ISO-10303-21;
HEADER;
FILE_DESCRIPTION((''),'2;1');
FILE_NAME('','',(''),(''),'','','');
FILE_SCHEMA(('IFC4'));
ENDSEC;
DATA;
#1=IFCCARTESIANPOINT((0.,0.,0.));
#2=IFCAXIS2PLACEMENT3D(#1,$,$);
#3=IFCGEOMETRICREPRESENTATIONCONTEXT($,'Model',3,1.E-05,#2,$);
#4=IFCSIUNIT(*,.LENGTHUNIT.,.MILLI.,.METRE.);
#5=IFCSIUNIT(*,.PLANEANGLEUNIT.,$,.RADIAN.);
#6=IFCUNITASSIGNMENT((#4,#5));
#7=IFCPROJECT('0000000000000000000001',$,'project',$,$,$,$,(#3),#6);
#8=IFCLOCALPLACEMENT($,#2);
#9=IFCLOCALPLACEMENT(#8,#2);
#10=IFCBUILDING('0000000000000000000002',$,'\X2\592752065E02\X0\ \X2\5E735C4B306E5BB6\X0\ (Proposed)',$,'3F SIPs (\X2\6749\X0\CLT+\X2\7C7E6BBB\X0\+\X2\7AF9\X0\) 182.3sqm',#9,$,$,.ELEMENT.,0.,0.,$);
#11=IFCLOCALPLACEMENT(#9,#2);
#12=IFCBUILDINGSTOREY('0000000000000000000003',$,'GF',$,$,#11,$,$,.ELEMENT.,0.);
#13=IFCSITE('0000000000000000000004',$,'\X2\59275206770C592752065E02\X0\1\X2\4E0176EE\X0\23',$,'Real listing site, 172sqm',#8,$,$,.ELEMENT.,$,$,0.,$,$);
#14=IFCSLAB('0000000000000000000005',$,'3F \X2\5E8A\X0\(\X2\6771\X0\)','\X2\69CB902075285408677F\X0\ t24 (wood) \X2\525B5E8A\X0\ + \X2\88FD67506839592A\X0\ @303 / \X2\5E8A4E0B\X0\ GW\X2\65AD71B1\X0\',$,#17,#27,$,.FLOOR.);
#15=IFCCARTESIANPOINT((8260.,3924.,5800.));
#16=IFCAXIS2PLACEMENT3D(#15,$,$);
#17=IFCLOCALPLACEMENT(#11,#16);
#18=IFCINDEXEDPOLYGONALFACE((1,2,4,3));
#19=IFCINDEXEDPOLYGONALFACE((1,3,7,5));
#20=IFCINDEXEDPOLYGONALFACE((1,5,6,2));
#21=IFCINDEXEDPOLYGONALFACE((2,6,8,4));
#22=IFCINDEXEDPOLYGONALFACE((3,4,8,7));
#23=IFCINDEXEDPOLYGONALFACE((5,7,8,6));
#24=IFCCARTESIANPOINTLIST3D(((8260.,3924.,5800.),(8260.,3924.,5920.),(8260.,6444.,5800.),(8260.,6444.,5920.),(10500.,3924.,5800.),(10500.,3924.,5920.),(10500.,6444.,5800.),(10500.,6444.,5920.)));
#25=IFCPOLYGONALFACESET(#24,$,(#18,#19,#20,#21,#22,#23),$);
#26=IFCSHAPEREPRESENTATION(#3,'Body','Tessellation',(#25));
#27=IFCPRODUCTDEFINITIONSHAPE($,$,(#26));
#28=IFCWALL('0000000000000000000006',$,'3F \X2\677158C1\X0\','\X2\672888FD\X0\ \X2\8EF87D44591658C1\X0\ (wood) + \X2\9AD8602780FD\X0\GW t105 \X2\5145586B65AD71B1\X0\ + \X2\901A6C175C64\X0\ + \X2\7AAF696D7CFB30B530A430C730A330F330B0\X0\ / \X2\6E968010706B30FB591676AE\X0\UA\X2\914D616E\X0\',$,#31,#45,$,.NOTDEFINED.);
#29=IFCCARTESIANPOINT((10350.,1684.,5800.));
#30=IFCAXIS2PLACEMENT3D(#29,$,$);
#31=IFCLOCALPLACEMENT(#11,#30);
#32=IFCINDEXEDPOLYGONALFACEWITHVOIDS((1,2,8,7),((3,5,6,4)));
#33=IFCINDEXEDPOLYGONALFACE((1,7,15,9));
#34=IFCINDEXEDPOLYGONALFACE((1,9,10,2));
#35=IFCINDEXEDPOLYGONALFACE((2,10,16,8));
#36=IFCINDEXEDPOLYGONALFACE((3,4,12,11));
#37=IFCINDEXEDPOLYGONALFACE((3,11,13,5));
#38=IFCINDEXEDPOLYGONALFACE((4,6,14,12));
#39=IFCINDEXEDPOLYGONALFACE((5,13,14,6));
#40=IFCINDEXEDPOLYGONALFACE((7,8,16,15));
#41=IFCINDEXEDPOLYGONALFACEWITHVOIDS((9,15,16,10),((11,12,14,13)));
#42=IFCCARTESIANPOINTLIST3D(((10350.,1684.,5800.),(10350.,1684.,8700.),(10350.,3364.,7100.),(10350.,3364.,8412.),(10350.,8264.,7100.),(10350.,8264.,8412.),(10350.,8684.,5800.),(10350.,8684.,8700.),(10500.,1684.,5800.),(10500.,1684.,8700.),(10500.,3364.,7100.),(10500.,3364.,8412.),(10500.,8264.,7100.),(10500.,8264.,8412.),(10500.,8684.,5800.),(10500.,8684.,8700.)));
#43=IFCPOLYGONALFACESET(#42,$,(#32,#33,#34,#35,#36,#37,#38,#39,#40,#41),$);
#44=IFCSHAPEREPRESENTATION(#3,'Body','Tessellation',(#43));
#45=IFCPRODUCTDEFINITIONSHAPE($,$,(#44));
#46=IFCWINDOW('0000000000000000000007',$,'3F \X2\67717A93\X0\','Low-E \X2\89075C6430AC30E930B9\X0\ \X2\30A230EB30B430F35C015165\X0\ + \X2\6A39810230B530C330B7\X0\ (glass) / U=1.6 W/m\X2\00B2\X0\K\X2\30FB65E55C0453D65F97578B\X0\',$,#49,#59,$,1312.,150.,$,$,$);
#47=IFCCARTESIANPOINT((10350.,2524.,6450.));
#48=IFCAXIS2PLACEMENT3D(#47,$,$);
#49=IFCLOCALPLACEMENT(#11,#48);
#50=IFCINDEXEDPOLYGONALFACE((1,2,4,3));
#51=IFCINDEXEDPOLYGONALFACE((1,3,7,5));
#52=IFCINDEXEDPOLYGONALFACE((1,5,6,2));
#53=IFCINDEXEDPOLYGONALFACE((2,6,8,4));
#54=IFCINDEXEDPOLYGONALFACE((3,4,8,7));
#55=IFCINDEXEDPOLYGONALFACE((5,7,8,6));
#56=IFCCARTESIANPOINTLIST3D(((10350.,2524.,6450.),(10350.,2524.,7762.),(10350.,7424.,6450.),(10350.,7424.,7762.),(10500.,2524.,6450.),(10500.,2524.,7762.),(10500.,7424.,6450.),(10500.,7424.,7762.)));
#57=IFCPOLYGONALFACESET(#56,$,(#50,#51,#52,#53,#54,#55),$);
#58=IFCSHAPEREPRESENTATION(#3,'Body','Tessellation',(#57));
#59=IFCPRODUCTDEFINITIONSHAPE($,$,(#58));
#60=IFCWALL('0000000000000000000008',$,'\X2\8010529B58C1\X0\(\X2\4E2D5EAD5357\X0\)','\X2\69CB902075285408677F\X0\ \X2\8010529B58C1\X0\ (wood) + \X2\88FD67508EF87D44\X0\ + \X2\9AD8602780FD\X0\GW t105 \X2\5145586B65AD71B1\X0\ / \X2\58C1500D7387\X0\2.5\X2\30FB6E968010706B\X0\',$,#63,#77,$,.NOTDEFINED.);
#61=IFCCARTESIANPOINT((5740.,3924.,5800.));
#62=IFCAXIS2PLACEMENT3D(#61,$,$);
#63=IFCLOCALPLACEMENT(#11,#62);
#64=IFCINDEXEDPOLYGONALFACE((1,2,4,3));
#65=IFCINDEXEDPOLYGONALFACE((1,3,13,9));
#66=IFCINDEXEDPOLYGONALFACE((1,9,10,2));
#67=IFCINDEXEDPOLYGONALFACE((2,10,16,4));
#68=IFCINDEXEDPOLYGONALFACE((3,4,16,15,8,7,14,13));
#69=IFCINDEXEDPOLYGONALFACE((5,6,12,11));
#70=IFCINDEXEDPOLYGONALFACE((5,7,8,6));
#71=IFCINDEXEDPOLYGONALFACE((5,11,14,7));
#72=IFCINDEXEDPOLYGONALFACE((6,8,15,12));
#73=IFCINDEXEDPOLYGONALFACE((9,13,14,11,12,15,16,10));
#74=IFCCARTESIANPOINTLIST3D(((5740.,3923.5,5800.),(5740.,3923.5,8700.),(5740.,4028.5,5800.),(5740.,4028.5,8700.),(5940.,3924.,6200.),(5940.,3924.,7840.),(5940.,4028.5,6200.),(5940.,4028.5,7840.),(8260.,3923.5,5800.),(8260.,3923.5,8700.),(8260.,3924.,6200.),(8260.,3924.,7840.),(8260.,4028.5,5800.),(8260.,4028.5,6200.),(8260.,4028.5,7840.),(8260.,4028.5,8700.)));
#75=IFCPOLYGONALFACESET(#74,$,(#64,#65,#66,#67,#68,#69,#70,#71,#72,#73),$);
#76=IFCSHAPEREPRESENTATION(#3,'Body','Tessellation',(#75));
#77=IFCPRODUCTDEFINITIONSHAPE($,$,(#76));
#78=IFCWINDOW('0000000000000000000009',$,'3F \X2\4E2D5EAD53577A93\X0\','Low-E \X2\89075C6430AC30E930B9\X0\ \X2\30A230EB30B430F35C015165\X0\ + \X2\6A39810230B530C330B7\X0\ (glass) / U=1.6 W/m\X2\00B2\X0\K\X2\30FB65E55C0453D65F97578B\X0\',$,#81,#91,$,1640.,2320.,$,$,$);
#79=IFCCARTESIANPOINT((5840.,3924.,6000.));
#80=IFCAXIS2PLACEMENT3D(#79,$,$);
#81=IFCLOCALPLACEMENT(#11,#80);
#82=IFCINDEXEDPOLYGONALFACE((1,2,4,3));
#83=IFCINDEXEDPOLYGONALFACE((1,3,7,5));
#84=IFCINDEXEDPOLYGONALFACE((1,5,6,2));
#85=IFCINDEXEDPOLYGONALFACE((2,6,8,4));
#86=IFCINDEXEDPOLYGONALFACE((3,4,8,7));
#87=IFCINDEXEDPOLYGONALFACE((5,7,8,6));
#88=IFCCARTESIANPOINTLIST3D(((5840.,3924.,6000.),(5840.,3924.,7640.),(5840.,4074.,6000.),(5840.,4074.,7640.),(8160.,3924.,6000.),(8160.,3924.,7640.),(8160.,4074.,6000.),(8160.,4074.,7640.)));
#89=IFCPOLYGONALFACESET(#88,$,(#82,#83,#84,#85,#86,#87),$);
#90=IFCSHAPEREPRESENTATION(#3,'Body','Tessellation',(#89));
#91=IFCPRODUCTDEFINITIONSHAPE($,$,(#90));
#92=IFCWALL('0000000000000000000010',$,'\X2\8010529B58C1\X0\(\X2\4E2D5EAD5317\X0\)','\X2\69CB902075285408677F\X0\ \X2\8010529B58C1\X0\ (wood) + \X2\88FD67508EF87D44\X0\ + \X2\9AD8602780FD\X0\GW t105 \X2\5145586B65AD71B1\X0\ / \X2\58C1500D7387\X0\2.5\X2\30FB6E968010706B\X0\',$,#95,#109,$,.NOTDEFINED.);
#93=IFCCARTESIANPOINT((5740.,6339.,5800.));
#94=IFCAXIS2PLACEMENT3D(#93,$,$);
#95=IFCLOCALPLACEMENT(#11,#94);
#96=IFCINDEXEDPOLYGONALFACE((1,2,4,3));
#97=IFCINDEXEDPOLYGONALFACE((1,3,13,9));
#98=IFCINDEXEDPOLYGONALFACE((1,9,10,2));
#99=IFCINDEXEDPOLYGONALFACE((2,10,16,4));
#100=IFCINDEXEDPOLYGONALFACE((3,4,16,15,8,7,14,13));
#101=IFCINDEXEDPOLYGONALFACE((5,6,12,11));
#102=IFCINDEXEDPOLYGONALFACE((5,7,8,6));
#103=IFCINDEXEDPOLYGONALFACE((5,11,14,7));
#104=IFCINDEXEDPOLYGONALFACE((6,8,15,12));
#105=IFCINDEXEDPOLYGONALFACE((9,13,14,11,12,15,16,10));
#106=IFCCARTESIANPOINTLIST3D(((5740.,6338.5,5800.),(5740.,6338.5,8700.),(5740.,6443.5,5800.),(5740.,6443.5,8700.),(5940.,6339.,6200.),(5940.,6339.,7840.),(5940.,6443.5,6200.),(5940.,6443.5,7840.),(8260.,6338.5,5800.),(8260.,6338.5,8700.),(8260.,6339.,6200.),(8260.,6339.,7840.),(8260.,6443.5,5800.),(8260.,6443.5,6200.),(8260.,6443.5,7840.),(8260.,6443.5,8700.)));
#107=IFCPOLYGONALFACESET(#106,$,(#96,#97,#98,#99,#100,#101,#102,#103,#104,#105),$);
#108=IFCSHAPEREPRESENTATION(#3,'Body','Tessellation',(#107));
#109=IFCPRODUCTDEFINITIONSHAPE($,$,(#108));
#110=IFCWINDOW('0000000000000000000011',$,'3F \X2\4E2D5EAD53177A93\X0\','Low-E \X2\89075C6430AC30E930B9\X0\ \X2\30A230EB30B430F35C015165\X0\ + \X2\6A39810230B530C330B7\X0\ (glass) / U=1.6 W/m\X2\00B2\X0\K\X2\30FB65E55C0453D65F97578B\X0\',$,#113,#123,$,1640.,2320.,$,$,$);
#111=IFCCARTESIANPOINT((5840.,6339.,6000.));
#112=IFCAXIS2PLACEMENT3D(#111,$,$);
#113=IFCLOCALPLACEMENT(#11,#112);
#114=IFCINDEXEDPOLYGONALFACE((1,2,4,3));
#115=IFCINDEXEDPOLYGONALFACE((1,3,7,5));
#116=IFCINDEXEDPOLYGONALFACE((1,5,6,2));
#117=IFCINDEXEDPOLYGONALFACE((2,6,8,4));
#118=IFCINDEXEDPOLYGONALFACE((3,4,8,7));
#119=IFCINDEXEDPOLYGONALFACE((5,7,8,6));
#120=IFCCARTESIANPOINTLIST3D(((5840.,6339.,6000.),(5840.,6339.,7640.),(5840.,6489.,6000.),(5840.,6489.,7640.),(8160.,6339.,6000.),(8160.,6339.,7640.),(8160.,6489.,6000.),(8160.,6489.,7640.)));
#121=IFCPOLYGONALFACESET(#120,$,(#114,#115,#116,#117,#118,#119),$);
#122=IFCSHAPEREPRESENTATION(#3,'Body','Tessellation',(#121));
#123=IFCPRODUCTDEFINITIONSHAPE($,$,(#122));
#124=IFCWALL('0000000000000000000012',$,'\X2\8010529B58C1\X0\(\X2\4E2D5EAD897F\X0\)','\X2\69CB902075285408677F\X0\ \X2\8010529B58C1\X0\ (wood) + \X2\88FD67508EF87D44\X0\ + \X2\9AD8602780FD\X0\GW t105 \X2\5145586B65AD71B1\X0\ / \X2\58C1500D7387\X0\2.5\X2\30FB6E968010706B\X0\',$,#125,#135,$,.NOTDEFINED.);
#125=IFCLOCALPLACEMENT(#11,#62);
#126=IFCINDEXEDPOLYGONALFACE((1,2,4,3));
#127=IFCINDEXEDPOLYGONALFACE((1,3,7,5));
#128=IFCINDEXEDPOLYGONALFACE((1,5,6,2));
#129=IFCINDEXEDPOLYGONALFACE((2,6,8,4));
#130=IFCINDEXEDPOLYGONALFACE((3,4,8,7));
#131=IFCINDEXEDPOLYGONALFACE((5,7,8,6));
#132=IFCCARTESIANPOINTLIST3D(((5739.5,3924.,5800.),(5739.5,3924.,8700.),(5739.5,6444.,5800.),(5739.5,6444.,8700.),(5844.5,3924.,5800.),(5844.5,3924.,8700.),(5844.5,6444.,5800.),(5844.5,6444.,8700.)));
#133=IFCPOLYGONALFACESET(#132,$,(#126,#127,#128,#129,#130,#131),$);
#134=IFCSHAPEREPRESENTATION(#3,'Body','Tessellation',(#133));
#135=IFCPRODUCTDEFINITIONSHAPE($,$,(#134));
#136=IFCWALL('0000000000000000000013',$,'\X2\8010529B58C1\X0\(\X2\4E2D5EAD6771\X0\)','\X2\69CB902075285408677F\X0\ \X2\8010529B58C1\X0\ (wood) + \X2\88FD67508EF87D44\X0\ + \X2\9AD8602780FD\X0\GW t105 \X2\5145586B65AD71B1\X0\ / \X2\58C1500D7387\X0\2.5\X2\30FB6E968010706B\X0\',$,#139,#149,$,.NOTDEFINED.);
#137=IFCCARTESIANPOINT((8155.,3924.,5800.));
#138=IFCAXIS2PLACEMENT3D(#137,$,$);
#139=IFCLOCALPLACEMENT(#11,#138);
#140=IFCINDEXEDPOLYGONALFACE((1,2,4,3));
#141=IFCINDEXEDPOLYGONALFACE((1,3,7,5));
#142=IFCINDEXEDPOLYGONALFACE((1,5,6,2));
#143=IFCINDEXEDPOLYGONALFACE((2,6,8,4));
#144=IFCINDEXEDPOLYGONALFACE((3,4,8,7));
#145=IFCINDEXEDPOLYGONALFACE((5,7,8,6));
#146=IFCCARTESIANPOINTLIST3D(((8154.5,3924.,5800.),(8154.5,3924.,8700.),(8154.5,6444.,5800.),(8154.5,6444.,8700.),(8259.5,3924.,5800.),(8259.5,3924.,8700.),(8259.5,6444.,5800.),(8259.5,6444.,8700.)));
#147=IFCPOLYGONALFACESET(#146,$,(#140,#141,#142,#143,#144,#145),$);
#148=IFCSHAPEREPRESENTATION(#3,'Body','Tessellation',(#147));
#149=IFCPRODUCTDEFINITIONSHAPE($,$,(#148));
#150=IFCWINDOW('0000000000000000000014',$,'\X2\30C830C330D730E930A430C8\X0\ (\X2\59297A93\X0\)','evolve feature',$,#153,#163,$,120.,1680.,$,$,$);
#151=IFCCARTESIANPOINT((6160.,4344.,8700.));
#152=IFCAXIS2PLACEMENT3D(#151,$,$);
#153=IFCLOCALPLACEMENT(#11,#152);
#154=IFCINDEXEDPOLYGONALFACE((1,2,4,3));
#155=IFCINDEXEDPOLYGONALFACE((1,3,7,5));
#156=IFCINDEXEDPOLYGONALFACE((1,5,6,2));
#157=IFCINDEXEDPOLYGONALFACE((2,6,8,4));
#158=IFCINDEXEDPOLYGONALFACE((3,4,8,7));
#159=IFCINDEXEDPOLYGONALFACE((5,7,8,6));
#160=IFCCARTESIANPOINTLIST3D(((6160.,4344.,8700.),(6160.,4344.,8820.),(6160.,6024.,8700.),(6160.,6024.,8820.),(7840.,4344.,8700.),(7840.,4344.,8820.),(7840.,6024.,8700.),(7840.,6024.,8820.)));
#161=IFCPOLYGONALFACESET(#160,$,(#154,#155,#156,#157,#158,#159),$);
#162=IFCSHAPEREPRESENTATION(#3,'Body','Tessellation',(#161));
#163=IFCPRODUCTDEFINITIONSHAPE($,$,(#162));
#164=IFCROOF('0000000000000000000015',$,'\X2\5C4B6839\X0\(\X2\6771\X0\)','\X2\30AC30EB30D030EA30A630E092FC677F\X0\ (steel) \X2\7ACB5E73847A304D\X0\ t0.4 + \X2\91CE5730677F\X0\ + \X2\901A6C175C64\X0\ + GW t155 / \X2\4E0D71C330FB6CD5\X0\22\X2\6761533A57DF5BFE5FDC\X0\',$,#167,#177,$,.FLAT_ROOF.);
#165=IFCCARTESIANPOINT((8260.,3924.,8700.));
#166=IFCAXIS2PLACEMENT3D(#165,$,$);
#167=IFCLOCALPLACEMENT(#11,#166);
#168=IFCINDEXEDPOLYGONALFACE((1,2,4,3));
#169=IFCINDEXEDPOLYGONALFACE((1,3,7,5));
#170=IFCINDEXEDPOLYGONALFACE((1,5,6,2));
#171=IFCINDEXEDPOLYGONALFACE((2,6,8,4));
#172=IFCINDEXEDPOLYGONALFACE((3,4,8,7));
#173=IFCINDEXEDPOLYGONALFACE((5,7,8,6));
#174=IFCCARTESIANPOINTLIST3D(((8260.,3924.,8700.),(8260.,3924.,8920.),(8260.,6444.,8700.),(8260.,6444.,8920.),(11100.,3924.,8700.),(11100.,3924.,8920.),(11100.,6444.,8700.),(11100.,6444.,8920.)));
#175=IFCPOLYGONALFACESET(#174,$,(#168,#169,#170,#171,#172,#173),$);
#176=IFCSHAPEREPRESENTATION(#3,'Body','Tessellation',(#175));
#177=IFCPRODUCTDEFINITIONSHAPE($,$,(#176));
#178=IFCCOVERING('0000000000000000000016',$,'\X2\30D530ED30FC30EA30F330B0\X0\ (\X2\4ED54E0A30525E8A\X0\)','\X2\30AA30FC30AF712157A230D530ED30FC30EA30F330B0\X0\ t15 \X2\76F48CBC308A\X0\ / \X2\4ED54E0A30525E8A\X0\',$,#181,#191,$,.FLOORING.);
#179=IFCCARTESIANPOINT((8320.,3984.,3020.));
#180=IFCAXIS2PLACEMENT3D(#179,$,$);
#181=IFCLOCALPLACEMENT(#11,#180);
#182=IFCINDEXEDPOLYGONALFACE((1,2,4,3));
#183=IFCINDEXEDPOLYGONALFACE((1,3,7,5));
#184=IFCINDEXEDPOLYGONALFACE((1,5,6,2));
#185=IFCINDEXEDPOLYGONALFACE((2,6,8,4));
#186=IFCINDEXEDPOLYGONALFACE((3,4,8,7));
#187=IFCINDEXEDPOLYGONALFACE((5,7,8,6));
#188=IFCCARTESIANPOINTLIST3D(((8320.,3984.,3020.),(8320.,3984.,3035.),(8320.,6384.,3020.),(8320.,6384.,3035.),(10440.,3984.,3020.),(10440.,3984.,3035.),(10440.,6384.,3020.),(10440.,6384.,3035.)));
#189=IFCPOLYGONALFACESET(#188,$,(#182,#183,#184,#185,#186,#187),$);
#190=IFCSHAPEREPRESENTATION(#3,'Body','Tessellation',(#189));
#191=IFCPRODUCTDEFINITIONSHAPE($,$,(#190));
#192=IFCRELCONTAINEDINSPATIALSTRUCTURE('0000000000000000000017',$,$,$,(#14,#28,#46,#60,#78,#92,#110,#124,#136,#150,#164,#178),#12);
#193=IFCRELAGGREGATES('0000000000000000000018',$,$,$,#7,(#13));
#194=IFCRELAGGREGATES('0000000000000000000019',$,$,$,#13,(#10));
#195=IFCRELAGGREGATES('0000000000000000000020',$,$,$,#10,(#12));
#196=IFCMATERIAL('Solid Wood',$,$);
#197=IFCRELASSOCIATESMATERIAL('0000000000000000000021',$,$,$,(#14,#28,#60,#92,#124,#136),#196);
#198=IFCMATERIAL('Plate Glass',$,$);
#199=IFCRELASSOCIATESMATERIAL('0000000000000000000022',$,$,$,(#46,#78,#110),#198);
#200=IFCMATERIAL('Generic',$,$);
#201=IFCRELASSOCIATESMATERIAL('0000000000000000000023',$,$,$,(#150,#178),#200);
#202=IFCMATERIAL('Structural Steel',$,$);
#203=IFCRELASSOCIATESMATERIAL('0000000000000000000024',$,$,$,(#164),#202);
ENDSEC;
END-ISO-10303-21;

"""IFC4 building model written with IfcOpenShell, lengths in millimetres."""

from ifc_helpers import new_model, si_unit, frame, frame_2d, origin, place, context, project, spatial, rectangle, extrude, material, element, fill, save


model = new_model("IFC4")

# Units and contexts
model_context = context("Model", 3, precision=1e-05, world=origin())
ifc_project = project(units=[si_unit("LENGTHUNIT", "METRE", prefix="MILLI"), si_unit("PLANEANGLEUNIT", "RADIAN")], contexts=[model_context])

# Site, building, storey
site_placement = place(None, origin())
site = spatial("IfcSite", under=ifc_project, at=site_placement, Name="大分県大分市1丁目23", ObjectType="Real listing site, 172sqm", CompositionType="ELEMENT", RefElevation=0.0)
building_placement = place(site_placement, origin())
building = spatial("IfcBuilding", under=site, at=building_placement, Name="大分市 平屋の家 (Proposed)", ObjectType="3F SIPs (杉CLT+籾殻+竹) 182.3sqm", CompositionType="ELEMENT", ElevationOfRefHeight=0.0, ElevationOfTerrain=0.0)
storey_placement = place(building_placement, origin())
storey = spatial("IfcBuildingStorey", under=building, at=storey_placement, Name="GF", CompositionType="ELEMENT", Elevation=0.0)

# Slab
ifc_material_1 = material(Name="Solid Wood")
slab_placement = place(storey_placement, frame((8260.0, 3924.0, 5800.0)))
element("IfcSlab", 1, at=slab_placement, inside=storey, material=ifc_material_1, Name="3F 床(東)", Description="構造用合板 t24 (wood) 剛床 + 製材根太 @303 / 床下 GW断熱", PredefinedType="FLOOR", context=model_context, shape_type="SweptSolid", body=[
    extrude(rectangle(XDim=2240.0, YDim=2520.0, at=frame_2d((1120.0, 1260.0))), frame((8260.0, 3924.0, 5800.0)), (0.0, 0.0, 1.0), 120.0),
])

# Walls, openings, windows
wall_1_placement = place(storey_placement, frame((10350.0, 1684.0, 5800.0)))
wall_1 = element("IfcWall", 2, at=wall_1_placement, inside=storey, material=ifc_material_1, Name="3F 東壁", Description="木製 軸組外壁 (wood) + 高性能GW t105 充填断熱 + 通気層 + 窯業系サイディング / 準耐火・外皮UA配慮", PredefinedType="NOTDEFINED", context=model_context, shape_type="SweptSolid", body=[
    extrude(rectangle(XDim=150.0, YDim=7000.0, at=frame_2d((75.0, 3500.0))), frame((10350.0, 1684.0, 5800.0)), (0.0, 0.0, 1.0), 2900.0),
])
opening_1_placement = place(storey_placement, frame((10350.0, 2524.0, 6450.0)))
opening_1 = element("IfcOpeningElement", 3, at=opening_1_placement, cuts=wall_1, PredefinedType="NOTDEFINED", context=model_context, shape_type="SweptSolid", body=[
    extrude(rectangle(XDim=150.0, YDim=4900.0, at=frame_2d((75.0, 2450.0))), frame((10350.0, 2524.0, 6450.0)), (0.0, 0.0, 1.0), 1312.0),
])
ifc_material_2 = material(Name="Plate Glass")
window_1_placement = place(storey_placement, frame((10350.0, 2524.0, 6450.0)))
window_1 = element("IfcWindow", 4, at=window_1_placement, inside=storey, material=ifc_material_2, Name="3F 東窓", Description="Low-E 複層ガラス アルゴン封入 + 樹脂サッシ (glass) / U=1.6 W/m²K・日射取得型", OverallHeight=1312.0, OverallWidth=150.0, context=model_context, shape_type="SweptSolid", body=[
    extrude(rectangle(XDim=150.0, YDim=4900.0, at=frame_2d((75.0, 2450.0))), frame((10350.0, 2524.0, 6450.0)), (0.0, 0.0, 1.0), 1312.0),
])
fill(opening_1, window_1)
wall_2_placement = place(storey_placement, frame((5740.0, 3924.0, 5800.0)))
wall_2 = element("IfcWall", 5, at=wall_2_placement, inside=storey, material=ifc_material_1, Name="耐力壁(中庭南)", Description="構造用合板 耐力壁 (wood) + 製材軸組 + 高性能GW t105 充填断熱 / 壁倍率2.5・準耐火", PredefinedType="NOTDEFINED", context=model_context, shape_type="SweptSolid", body=[
    extrude(rectangle(XDim=2520.0, YDim=105.0, at=frame_2d((1260.0, 52.0))), frame((5740.0, 3924.0, 5800.0)), (0.0, 0.0, 1.0), 2900.0),
])
opening_2_placement = place(storey_placement, frame((5840.0, 3924.0, 6000.0)))
opening_2 = element("IfcOpeningElement", 6, at=opening_2_placement, cuts=wall_2, PredefinedType="NOTDEFINED", context=model_context, shape_type="SweptSolid", body=[
    extrude(rectangle(XDim=2320.0, YDim=150.0, at=frame_2d((1160.0, 75.0))), frame((5840.0, 3924.0, 6000.0)), (0.0, 0.0, 1.0), 1640.0),
])
window_2_placement = place(storey_placement, frame((5840.0, 3924.0, 6000.0)))
window_2 = element("IfcWindow", 7, at=window_2_placement, inside=storey, material=ifc_material_2, Name="3F 中庭南窓", Description="Low-E 複層ガラス アルゴン封入 + 樹脂サッシ (glass) / U=1.6 W/m²K・日射取得型", OverallHeight=1640.0, OverallWidth=2320.0, context=model_context, shape_type="SweptSolid", body=[
    extrude(rectangle(XDim=2320.0, YDim=150.0, at=frame_2d((1160.0, 75.0))), frame((5840.0, 3924.0, 6000.0)), (0.0, 0.0, 1.0), 1640.0),
])
fill(opening_2, window_2)
wall_3_placement = place(storey_placement, frame((5740.0, 6339.0, 5800.0)))
wall_3 = element("IfcWall", 8, at=wall_3_placement, inside=storey, material=ifc_material_1, Name="耐力壁(中庭北)", Description="構造用合板 耐力壁 (wood) + 製材軸組 + 高性能GW t105 充填断熱 / 壁倍率2.5・準耐火", PredefinedType="NOTDEFINED", context=model_context, shape_type="SweptSolid", body=[
    extrude(rectangle(XDim=2520.0, YDim=105.0, at=frame_2d((1260.0, 52.0))), frame((5740.0, 6339.0, 5800.0)), (0.0, 0.0, 1.0), 2900.0),
])
opening_3_placement = place(storey_placement, frame((5840.0, 6339.0, 6000.0)))
opening_3 = element("IfcOpeningElement", 9, at=opening_3_placement, cuts=wall_3, PredefinedType="NOTDEFINED", context=model_context, shape_type="SweptSolid", body=[
    extrude(rectangle(XDim=2320.0, YDim=150.0, at=frame_2d((1160.0, 75.0))), frame((5840.0, 6339.0, 6000.0)), (0.0, 0.0, 1.0), 1640.0),
])
window_3_placement = place(storey_placement, frame((5840.0, 6339.0, 6000.0)))
window_3 = element("IfcWindow", 10, at=window_3_placement, inside=storey, material=ifc_material_2, Name="3F 中庭北窓", Description="Low-E 複層ガラス アルゴン封入 + 樹脂サッシ (glass) / U=1.6 W/m²K・日射取得型", OverallHeight=1640.0, OverallWidth=2320.0, context=model_context, shape_type="SweptSolid", body=[
    extrude(rectangle(XDim=2320.0, YDim=150.0, at=frame_2d((1160.0, 75.0))), frame((5840.0, 6339.0, 6000.0)), (0.0, 0.0, 1.0), 1640.0),
])
fill(opening_3, window_3)

# Walls
wall_4_placement = place(storey_placement, frame((5740.0, 3924.0, 5800.0)))
element("IfcWall", 11, at=wall_4_placement, inside=storey, material=ifc_material_1, Name="耐力壁(中庭西)", Description="構造用合板 耐力壁 (wood) + 製材軸組 + 高性能GW t105 充填断熱 / 壁倍率2.5・準耐火", PredefinedType="NOTDEFINED", context=model_context, shape_type="SweptSolid", body=[
    extrude(rectangle(XDim=105.0, YDim=2520.0, at=frame_2d((52.0, 1260.0))), frame((5740.0, 3924.0, 5800.0)), (0.0, 0.0, 1.0), 2900.0),
])
wall_5_placement = place(storey_placement, frame((8155.0, 3924.0, 5800.0)))
element("IfcWall", 12, at=wall_5_placement, inside=storey, material=ifc_material_1, Name="耐力壁(中庭東)", Description="構造用合板 耐力壁 (wood) + 製材軸組 + 高性能GW t105 充填断熱 / 壁倍率2.5・準耐火", PredefinedType="NOTDEFINED", context=model_context, shape_type="SweptSolid", body=[
    extrude(rectangle(XDim=105.0, YDim=2520.0, at=frame_2d((52.0, 1260.0))), frame((8155.0, 3924.0, 5800.0)), (0.0, 0.0, 1.0), 2900.0),
])

# Window
ifc_material_3 = material(Name="Generic")
window_4_placement = place(storey_placement, frame((6160.0, 4344.0, 8700.0)))
element("IfcWindow", 13, at=window_4_placement, inside=storey, material=ifc_material_3, Name="トップライト (天窓)", Description="evolve feature", OverallHeight=120.0, OverallWidth=1680.0, context=model_context, shape_type="SweptSolid", body=[
    extrude(rectangle(XDim=1680.0, YDim=1680.0, at=frame_2d((840.0, 840.0))), frame((6160.0, 4344.0, 8700.0)), (0.0, 0.0, 1.0), 120.0),
])

# Roof
ifc_material_4 = material(Name="Structural Steel")
for number, where, name in (
    (14, (8260.0, 3924.0, 8700.0), "屋根(東)"),
):
    element("IfcRoof", number, at=place(storey_placement, frame(where)), inside=storey, material=ifc_material_4, Name=name, Description="ガルバリウム鋼板 (steel) 立平葺き t0.4 + 野地板 + 通気層 + GW t155 / 不燃・法22条区域対応", PredefinedType="FLAT_ROOF", context=model_context, shape_type="SweptSolid", body=[
        extrude(rectangle(XDim=2840.0, YDim=2520.0, at=frame_2d((1420.0, 1260.0))), frame((8260.0, 3924.0, 8700.0)), (0.0, 0.0, 1.0), 220.0),
    ])

# Covering
covering_1_placement = place(storey_placement, frame((8320.0, 3984.0, 3020.0)))
element("IfcCovering", 15, at=covering_1_placement, inside=storey, material=ifc_material_3, Name="フローリング (仕上げ床)", Description="オーク無垢フローリング t15 直貼り / 仕上げ床", PredefinedType="FLOORING", context=model_context, shape_type="SweptSolid", body=[
    extrude(rectangle(XDim=2120.0, YDim=2400.0, at=frame_2d((1060.0, 1200.0))), frame((8320.0, 3984.0, 3020.0)), (0.0, 0.0, 1.0), 15.0),
])

save(model, "model.ifc")
